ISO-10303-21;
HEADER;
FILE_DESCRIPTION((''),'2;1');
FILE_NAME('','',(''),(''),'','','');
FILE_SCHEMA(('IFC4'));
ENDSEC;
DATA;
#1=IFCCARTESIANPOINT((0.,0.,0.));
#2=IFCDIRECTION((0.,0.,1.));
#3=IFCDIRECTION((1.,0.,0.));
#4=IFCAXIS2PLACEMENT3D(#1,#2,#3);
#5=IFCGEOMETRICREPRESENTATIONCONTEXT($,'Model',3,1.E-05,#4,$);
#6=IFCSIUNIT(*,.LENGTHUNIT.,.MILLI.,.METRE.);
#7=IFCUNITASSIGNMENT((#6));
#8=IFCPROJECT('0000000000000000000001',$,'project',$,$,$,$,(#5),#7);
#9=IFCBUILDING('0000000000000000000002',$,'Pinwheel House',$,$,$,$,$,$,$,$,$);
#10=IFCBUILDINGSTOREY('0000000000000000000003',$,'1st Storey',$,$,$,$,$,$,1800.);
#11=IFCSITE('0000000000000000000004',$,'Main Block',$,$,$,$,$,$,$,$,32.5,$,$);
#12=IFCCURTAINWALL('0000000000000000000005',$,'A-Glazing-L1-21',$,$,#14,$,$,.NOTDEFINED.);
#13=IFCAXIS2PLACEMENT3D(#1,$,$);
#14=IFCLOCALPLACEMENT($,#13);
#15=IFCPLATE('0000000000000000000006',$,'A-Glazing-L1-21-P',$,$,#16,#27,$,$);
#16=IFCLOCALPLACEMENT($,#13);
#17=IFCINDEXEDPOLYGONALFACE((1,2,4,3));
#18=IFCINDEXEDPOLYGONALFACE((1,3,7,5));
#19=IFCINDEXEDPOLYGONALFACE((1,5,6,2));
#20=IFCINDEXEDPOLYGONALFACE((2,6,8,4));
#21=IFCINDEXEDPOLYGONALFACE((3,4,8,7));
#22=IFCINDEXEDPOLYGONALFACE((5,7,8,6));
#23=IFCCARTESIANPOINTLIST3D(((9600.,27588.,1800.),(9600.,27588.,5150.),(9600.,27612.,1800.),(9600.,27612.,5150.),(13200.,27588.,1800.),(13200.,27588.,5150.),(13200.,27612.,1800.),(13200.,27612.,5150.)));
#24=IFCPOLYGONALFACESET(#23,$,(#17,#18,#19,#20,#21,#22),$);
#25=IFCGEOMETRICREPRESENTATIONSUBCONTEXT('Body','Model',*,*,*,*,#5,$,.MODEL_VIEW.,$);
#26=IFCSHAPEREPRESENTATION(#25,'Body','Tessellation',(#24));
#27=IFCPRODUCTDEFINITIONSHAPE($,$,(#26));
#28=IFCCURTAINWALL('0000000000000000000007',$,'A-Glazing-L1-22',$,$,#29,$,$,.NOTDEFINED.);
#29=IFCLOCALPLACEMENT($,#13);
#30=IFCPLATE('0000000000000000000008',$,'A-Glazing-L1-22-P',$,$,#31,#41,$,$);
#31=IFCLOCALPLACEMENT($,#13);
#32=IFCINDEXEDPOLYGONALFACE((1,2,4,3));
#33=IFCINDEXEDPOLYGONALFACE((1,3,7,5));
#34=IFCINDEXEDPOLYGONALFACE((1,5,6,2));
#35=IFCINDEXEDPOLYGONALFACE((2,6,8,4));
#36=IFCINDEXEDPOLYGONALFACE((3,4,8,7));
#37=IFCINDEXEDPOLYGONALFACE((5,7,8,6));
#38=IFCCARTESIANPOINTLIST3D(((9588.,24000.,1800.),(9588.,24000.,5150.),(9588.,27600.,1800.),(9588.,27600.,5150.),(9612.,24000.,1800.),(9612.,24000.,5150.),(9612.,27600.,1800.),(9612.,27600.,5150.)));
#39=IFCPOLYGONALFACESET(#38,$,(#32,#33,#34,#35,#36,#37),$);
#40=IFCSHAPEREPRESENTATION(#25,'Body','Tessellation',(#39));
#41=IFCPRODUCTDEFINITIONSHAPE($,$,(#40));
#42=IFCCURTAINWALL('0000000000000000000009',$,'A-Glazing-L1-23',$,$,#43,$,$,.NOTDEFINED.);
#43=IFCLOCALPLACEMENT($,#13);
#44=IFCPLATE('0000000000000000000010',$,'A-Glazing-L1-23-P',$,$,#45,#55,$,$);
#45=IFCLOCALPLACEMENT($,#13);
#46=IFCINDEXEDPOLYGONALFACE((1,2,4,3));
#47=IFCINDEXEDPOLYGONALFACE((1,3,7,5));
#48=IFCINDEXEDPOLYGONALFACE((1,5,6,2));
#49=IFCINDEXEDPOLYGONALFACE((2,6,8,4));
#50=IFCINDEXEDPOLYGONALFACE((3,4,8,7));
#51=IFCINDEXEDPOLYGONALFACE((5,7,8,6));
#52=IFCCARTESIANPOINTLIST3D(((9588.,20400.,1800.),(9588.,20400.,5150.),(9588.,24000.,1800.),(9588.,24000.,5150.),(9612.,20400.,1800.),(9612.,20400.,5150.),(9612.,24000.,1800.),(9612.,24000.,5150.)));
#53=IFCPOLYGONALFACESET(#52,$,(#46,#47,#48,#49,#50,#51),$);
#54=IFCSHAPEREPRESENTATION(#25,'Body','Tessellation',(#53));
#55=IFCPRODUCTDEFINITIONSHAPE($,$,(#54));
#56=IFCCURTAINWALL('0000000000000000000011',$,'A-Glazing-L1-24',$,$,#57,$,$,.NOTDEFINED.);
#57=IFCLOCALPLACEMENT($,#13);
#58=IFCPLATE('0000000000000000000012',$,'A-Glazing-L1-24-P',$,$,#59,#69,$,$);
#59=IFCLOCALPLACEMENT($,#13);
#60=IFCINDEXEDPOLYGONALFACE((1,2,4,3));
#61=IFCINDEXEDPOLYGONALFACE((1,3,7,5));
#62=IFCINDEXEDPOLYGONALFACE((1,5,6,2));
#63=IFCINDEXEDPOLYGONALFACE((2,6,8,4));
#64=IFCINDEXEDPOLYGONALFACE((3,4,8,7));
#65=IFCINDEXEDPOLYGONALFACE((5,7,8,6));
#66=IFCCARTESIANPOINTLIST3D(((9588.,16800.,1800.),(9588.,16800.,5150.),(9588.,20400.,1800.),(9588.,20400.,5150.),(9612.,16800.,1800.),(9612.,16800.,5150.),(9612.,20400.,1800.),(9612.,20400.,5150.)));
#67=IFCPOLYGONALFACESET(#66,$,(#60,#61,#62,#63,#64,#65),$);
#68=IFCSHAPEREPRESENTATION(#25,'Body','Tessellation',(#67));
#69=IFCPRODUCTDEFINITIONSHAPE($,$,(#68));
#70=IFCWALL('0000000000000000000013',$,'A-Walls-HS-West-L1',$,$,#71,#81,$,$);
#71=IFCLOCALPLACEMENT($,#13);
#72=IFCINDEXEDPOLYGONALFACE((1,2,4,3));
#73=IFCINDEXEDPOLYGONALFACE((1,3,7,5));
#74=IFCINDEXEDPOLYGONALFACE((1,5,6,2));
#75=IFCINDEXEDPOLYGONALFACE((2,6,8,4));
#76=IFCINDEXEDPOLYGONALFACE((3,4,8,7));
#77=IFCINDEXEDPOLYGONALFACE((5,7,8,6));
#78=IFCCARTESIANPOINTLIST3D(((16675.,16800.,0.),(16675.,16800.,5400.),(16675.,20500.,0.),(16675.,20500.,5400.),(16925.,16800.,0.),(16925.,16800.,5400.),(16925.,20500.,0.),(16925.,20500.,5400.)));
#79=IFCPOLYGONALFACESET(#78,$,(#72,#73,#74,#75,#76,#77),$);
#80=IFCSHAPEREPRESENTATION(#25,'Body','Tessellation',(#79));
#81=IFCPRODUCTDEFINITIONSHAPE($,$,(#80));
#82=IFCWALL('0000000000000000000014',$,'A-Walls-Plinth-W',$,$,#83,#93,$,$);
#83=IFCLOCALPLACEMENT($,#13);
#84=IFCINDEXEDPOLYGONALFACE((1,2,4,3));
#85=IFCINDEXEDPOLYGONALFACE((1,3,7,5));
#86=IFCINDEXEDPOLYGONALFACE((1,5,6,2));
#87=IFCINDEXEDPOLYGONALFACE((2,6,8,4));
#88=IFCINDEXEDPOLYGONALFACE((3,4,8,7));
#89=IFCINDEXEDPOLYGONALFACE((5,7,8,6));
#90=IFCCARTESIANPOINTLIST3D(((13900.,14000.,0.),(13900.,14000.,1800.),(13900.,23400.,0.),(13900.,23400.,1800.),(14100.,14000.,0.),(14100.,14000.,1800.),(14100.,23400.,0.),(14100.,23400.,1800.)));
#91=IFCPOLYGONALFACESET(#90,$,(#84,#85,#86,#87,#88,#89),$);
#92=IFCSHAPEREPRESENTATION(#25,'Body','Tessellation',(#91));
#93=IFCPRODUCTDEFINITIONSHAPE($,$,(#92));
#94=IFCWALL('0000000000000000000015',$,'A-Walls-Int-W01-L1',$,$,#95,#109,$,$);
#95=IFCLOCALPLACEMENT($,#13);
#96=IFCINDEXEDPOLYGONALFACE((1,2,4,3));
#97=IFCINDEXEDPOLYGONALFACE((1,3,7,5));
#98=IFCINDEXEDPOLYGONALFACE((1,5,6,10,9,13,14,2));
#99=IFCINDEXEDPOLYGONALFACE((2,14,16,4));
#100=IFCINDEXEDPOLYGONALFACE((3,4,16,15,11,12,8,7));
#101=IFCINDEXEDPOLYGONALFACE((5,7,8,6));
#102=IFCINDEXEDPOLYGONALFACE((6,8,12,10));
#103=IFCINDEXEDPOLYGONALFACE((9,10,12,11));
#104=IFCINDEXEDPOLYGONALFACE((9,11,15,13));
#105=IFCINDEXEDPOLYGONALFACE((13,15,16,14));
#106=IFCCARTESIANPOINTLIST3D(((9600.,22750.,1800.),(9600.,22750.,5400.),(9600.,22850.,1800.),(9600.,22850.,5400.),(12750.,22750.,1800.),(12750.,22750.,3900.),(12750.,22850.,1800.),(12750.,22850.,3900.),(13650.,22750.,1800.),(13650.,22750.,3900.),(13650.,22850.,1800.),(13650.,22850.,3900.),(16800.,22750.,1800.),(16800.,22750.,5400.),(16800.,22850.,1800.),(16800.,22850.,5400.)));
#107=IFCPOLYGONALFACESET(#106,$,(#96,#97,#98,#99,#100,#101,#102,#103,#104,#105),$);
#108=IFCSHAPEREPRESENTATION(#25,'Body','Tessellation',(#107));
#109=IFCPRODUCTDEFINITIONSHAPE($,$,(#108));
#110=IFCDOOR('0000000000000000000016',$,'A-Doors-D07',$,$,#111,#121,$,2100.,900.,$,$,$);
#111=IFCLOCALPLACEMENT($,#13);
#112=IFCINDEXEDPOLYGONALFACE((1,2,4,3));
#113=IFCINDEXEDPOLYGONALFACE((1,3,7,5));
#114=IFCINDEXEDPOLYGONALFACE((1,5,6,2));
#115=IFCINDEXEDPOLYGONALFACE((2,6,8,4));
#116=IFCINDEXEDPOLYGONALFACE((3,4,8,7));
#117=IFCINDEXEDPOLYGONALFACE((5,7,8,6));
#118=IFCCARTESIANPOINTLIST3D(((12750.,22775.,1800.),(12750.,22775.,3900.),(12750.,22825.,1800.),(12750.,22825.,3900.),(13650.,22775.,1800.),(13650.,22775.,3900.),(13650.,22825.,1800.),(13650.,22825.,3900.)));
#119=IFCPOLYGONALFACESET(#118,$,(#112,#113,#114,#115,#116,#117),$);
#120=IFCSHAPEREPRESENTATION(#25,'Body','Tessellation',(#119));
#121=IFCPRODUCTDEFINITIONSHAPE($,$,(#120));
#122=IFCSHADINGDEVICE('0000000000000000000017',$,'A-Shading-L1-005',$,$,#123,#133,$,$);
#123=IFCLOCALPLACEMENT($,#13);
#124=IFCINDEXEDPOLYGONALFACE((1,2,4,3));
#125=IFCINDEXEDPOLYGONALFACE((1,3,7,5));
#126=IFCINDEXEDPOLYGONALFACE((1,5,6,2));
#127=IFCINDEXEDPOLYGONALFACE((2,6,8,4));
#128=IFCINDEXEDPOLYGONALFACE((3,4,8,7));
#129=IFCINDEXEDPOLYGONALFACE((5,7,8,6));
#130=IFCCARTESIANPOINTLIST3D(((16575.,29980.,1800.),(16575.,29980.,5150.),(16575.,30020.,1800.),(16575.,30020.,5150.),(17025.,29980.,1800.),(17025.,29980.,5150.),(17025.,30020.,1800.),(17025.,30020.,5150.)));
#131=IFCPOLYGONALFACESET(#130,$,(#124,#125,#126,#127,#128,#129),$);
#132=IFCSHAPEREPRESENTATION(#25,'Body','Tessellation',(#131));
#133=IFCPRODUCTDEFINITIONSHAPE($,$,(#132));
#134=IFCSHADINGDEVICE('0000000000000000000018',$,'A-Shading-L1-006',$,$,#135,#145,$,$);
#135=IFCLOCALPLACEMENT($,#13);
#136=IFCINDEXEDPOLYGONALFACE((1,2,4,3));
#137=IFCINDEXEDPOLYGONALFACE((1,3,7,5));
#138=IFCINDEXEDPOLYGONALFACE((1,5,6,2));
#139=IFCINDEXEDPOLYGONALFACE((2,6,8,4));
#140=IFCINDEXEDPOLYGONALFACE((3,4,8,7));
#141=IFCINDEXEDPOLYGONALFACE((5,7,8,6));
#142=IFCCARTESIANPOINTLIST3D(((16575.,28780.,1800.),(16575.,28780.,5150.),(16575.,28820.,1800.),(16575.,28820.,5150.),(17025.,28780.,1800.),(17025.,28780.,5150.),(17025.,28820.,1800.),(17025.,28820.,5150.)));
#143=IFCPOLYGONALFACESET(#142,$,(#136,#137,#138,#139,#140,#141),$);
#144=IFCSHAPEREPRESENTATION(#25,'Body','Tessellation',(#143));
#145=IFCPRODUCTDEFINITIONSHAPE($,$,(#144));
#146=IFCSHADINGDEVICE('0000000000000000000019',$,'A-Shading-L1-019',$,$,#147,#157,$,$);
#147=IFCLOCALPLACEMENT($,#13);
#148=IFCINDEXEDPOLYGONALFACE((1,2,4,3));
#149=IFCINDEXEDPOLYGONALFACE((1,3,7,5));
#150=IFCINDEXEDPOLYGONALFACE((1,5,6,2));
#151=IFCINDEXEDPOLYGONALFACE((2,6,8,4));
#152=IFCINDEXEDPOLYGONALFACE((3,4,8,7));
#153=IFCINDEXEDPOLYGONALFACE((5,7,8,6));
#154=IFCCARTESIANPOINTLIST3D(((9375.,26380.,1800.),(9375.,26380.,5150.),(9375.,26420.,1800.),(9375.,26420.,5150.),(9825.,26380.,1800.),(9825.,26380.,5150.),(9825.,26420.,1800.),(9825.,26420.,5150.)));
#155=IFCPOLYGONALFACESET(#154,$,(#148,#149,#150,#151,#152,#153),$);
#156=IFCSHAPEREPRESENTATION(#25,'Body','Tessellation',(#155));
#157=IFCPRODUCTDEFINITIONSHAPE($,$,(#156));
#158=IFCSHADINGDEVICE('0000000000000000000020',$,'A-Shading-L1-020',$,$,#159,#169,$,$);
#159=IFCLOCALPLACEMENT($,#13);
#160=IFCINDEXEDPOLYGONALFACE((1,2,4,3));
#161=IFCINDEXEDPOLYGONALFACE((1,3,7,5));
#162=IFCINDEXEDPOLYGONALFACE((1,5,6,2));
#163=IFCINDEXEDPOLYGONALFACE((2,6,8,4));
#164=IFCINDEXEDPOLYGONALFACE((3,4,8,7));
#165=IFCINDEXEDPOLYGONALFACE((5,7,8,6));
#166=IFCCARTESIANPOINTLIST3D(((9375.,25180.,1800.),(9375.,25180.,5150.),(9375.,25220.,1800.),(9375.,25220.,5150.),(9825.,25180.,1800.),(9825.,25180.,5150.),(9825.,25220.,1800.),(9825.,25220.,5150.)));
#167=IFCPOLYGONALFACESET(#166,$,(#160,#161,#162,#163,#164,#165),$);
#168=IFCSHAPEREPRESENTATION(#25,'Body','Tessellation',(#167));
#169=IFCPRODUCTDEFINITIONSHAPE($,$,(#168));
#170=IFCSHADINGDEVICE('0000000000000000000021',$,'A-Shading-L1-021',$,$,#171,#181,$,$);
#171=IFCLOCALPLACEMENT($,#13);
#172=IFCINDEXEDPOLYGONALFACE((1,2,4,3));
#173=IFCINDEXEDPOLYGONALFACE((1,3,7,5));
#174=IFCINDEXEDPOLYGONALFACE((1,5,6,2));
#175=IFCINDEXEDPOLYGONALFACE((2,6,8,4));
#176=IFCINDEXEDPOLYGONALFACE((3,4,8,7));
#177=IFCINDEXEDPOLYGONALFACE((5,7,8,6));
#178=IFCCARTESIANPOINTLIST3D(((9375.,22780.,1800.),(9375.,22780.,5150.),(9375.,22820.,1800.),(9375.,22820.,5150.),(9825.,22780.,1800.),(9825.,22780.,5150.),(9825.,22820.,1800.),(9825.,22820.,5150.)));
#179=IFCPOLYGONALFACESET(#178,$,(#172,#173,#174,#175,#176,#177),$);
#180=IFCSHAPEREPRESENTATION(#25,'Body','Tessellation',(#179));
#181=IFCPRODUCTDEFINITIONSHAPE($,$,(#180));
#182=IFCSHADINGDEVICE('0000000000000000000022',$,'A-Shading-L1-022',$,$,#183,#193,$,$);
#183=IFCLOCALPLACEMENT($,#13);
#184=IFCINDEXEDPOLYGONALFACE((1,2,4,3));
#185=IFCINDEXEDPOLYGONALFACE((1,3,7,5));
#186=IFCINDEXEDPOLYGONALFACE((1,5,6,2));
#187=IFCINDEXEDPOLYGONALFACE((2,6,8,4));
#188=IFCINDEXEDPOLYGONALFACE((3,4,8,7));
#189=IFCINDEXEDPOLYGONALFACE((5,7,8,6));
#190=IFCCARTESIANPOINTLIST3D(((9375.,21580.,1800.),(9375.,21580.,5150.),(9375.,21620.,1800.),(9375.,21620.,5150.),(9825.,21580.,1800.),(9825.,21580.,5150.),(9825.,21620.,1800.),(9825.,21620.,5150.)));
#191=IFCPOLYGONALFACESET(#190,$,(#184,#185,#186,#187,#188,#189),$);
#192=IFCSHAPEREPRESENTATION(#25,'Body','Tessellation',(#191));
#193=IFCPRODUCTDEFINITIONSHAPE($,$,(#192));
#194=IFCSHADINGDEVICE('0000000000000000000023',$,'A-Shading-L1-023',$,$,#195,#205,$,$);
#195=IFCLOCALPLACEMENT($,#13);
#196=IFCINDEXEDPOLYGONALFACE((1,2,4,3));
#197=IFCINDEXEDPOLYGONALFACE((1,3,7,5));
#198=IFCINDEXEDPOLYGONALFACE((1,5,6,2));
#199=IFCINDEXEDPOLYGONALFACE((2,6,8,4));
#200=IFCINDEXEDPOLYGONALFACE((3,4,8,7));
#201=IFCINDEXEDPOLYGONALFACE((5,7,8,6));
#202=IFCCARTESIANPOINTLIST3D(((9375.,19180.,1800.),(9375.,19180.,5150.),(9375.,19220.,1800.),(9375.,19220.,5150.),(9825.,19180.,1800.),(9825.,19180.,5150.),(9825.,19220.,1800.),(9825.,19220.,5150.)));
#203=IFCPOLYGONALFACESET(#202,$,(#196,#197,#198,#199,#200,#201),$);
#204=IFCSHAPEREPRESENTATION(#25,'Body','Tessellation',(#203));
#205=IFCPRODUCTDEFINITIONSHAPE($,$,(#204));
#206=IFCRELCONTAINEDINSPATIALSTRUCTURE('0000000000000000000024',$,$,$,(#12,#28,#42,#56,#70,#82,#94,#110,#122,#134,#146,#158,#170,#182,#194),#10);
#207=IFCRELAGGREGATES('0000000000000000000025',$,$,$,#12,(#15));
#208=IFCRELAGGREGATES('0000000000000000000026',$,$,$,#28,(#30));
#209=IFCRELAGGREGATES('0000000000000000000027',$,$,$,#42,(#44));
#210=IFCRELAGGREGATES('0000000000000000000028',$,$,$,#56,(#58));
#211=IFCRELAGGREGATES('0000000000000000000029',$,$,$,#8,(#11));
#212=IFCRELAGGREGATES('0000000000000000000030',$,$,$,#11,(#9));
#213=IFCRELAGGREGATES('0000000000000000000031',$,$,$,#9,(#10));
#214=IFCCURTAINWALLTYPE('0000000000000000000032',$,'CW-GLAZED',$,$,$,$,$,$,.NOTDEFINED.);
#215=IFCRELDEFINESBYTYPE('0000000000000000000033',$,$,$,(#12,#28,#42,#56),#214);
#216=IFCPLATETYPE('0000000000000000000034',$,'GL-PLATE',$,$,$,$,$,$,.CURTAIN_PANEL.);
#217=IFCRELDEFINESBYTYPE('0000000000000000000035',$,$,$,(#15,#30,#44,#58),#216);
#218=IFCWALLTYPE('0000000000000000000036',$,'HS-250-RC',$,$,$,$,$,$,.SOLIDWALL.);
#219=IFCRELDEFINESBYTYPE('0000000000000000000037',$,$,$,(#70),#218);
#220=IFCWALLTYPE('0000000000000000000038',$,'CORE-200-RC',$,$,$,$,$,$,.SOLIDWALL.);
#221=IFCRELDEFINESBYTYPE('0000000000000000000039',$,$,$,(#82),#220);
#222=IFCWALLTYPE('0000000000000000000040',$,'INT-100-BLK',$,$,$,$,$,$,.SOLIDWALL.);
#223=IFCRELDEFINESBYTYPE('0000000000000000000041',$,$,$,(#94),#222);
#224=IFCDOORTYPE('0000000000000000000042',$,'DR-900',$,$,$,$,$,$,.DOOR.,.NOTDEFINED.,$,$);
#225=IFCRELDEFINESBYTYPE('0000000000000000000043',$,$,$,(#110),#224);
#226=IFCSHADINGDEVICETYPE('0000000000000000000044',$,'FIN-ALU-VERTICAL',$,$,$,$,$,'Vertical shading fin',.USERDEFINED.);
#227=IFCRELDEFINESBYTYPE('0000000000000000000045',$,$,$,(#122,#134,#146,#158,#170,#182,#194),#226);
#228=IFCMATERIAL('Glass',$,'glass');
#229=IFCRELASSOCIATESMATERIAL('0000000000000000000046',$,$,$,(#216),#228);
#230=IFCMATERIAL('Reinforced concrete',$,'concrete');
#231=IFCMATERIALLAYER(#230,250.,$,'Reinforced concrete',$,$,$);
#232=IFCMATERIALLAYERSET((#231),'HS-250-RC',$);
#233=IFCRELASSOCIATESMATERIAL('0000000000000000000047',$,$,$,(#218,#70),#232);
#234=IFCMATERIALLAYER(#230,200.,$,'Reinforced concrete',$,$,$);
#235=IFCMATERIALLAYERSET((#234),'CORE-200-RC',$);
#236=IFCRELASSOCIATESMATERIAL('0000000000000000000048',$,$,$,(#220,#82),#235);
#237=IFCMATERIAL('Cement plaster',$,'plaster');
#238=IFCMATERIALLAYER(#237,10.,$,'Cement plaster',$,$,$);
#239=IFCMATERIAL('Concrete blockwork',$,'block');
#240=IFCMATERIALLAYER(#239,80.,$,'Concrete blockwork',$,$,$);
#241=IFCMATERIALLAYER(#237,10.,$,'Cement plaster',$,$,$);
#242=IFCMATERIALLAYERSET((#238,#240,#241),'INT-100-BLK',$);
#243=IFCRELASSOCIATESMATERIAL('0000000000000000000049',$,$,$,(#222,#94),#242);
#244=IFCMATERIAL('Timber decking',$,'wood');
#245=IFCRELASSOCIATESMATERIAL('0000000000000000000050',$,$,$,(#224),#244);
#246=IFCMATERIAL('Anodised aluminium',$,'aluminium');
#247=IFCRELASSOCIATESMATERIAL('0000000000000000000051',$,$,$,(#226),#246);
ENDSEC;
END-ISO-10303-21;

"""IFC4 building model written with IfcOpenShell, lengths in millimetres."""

from ifc_helpers import new_model, si_unit, frame, origin_with_axes, place, context, subcontext, project, spatial, indexed_curve, outline, extrude, material, layer, layer_set, layer_usage, type_object, element, fill, aggregate, save


model = new_model("IFC4")

# Units and contexts
model_context = context("Model", 3, precision=1e-05, world=origin_with_axes())
body_context = subcontext(model_context, "Body", "Model", "MODEL_VIEW")
ifc_project = project(units=[si_unit("LENGTHUNIT", "METRE", prefix="MILLI")], contexts=[model_context])

# Site, building, storey
site = spatial("IfcSite", under=ifc_project, Name="Main Block", RefElevation=32.5)
building = spatial("IfcBuilding", under=site, Name="Pinwheel House")
storey = spatial("IfcBuildingStorey", under=building, Name="1st Storey", Elevation=1800.0)

# Shared definitions
ifc_material_1 = material(Name="Anodised aluminium", Category="aluminium")

# Curtain walls, plates
curtain_wall_type = type_object("IfcCurtainWallType", Name="CW-GLAZED", PredefinedType="NOTDEFINED")
ifc_material_2 = material(Name="Glass", Category="glass")
plate_type = type_object("IfcPlateType", Name="GL-PLATE", PredefinedType="CURTAIN_PANEL", material=ifc_material_2)
curtain_wall_1 = element("IfcCurtainWall", 1, inside=storey, type_object=curtain_wall_type, Name="A-Glazing-L1-21", PredefinedType="NOTDEFINED")
plate_1_placement = place(None, frame((11400.0, 27600.0, 1800.0), z_axis=(0.0, 0.0, 1.0), x_axis=(-1.0, 0.0, 0.0)))
plate_1 = element("IfcPlate", 2, at=plate_1_placement, type_object=plate_type, Name="A-Glazing-L1-21-P", context=body_context, shape_type="SweptSolid", body=[
    extrude(outline(indexed_curve([(-1800.0, -12.0), (1800.0, -12.0), (1800.0, 12.0), (-1800.0, 12.0)])), None, (0.0, 0.0, 1.0), 3350.0),
])
aggregate(curtain_wall_1, [plate_1])
curtain_wall_2 = element("IfcCurtainWall", 3, inside=storey, type_object=curtain_wall_type, Name="A-Glazing-L1-22", PredefinedType="NOTDEFINED")
plate_2_placement = place(None, frame((9600.0, 25800.0, 1800.0), z_axis=(0.0, 0.0, 1.0), x_axis=(0.0, -1.0, 0.0)))
plate_2 = element("IfcPlate", 4, at=plate_2_placement, type_object=plate_type, Name="A-Glazing-L1-22-P", context=body_context, shape_type="SweptSolid", body=[
    extrude(outline(indexed_curve([(-1800.0, -12.0), (1800.0, -12.0), (1800.0, 12.0), (-1800.0, 12.0)])), None, (0.0, 0.0, 1.0), 3350.0),
])
aggregate(curtain_wall_2, [plate_2])
curtain_wall_3 = element("IfcCurtainWall", 5, inside=storey, type_object=curtain_wall_type, Name="A-Glazing-L1-23", PredefinedType="NOTDEFINED")
plate_3_placement = place(None, frame((9600.0, 22200.0, 1800.0), z_axis=(0.0, 0.0, 1.0), x_axis=(0.0, -1.0, 0.0)))
plate_3 = element("IfcPlate", 6, at=plate_3_placement, type_object=plate_type, Name="A-Glazing-L1-23-P", context=body_context, shape_type="SweptSolid", body=[
    extrude(outline(indexed_curve([(-1800.0, -12.0), (1800.0, -12.0), (1800.0, 12.0), (-1800.0, 12.0)])), None, (0.0, 0.0, 1.0), 3350.0),
])
aggregate(curtain_wall_3, [plate_3])
curtain_wall_4 = element("IfcCurtainWall", 7, inside=storey, type_object=curtain_wall_type, Name="A-Glazing-L1-24", PredefinedType="NOTDEFINED")
plate_4_placement = place(None, frame((9600.0, 18600.0, 1800.0), z_axis=(0.0, 0.0, 1.0), x_axis=(0.0, -1.0, 0.0)))
plate_4 = element("IfcPlate", 8, at=plate_4_placement, type_object=plate_type, Name="A-Glazing-L1-24-P", context=body_context, shape_type="SweptSolid", body=[
    extrude(outline(indexed_curve([(-1800.0, -12.0), (1800.0, -12.0), (1800.0, 12.0), (-1800.0, 12.0)])), None, (0.0, 0.0, 1.0), 3350.0),
])
aggregate(curtain_wall_4, [plate_4])

# Walls
ifc_material_3 = material(Name="Reinforced concrete", Category="concrete")
ifc_layer_1 = layer(ifc_material_3, 250.0, Name="Reinforced concrete")
ifc_layer_set_1 = layer_set([ifc_layer_1], Name="HS-250-RC")
ifc_layer_usage_1 = layer_usage(ifc_layer_set_1, "AXIS2", "POSITIVE", 0.0)
wall_type_1 = type_object("IfcWallType", Name="HS-250-RC", PredefinedType="SOLIDWALL", material=ifc_layer_set_1)
wall_1_placement = place(None, frame((16675.0, 20500.0, 0.0), z_axis=(0.0, 0.0, 1.0), x_axis=(0.0, -1.0, 0.0)))
element("IfcWall", 9, at=wall_1_placement, inside=storey, type_object=wall_type_1, material=ifc_layer_usage_1, Name="A-Walls-HS-West-L1", context=body_context, shape_type="SweptSolid", body=[
    extrude(outline(indexed_curve([(0.0, 0.0), (0.0, 250.0), (3700.0, 250.0), (3700.0, 0.0), (0.0, 0.0)], self_intersect=False)), origin_with_axes(), (0.0, 0.0, 1.0), 5400.0),
])
ifc_layer_2 = layer(ifc_material_3, 200.0, Name="Reinforced concrete")
ifc_layer_set_2 = layer_set([ifc_layer_2], Name="CORE-200-RC")
ifc_layer_usage_2 = layer_usage(ifc_layer_set_2, "AXIS2", "POSITIVE", 0.0)
wall_type_2 = type_object("IfcWallType", Name="CORE-200-RC", PredefinedType="SOLIDWALL", material=ifc_layer_set_2)
wall_2_placement = place(None, frame((13900.0, 23400.0, 0.0), z_axis=(0.0, 0.0, 1.0), x_axis=(0.0, -1.0, 0.0)))
element("IfcWall", 10, at=wall_2_placement, inside=storey, type_object=wall_type_2, material=ifc_layer_usage_2, Name="A-Walls-Plinth-W", context=body_context, shape_type="SweptSolid", body=[
    extrude(outline(indexed_curve([(0.0, 0.0), (0.0, 200.0), (9400.0, 200.0), (9400.0, 0.0), (0.0, 0.0)], self_intersect=False)), origin_with_axes(), (0.0, 0.0, 1.0), 1800.0),
])

# Wall, opening, door
ifc_material_4 = material(Name="Cement plaster", Category="plaster")
ifc_layer_3 = layer(ifc_material_4, 10.0, Name="Cement plaster")
ifc_material_5 = material(Name="Concrete blockwork", Category="block")
ifc_layer_4 = layer(ifc_material_5, 80.0, Name="Concrete blockwork")
ifc_layer_5 = layer(ifc_material_4, 10.0, Name="Cement plaster")
ifc_layer_set_3 = layer_set([ifc_layer_3, ifc_layer_4, ifc_layer_5], Name="INT-100-BLK")
ifc_layer_usage_3 = layer_usage(ifc_layer_set_3, "AXIS2", "POSITIVE", 0.0)
wall_type_3 = type_object("IfcWallType", Name="INT-100-BLK", PredefinedType="SOLIDWALL", material=ifc_layer_set_3)
wall_3_placement = place(None, frame((9600.0, 22750.0, 1800.0), z_axis=(0.0, 0.0, 1.0), x_axis=(1.0, 0.0, 0.0)))
wall_3 = element("IfcWall", 11, at=wall_3_placement, inside=storey, type_object=wall_type_3, material=ifc_layer_usage_3, Name="A-Walls-Int-W01-L1", context=body_context, shape_type="SweptSolid", body=[
    extrude(outline(indexed_curve([(0.0, 0.0), (0.0, 100.0), (7200.0, 100.0), (7200.0, 0.0), (0.0, 0.0)], self_intersect=False)), origin_with_axes(), (0.0, 0.0, 1.0), 3600.0),
])
opening_placement = place(wall_3_placement, frame((3600.0, 50.0, 0.0), z_axis=(0.0, 0.0, 1.0), x_axis=(1.0, 0.0, 0.0)))
opening = element("IfcOpeningElement", 12, at=opening_placement, cuts=wall_3, PredefinedType="OPENING", context=body_context, shape_type="SweptSolid", body=[
    extrude(outline(indexed_curve([(-450.0, -100.0), (450.0, -100.0), (450.0, 100.0), (-450.0, 100.0)])), None, (0.0, 0.0, 1.0), 2100.0),
])
ifc_material_6 = material(Name="Timber decking", Category="wood")
door_type = type_object("IfcDoorType", Name="DR-900", OperationType="NOTDEFINED", PredefinedType="DOOR", material=ifc_material_6)
door_placement = place(None, frame((13200.0, 22800.0, 1800.0), z_axis=(0.0, 0.0, 1.0), x_axis=(1.0, 0.0, 0.0)))
door = element("IfcDoor", 13, at=door_placement, inside=storey, type_object=door_type, Name="A-Doors-D07", OverallHeight=2100.0, OverallWidth=900.0, context=body_context, shape_type="SweptSolid", body=[
    extrude(outline(indexed_curve([(-450.0, -25.0), (450.0, -25.0), (450.0, 25.0), (-450.0, 25.0)])), None, (0.0, 0.0, 1.0), 2100.0),
])
fill(opening, door)

# Shading devices
shading_device_type = type_object("IfcShadingDeviceType", Name="FIN-ALU-VERTICAL", ElementType="Vertical shading fin", PredefinedType="USERDEFINED", material=ifc_material_1)
for number, where, z_axis, x_axis, name in (
    (14, (16800.0, 30000.0, 1800.0), (0.0, 0.0, 1.0), (0.0, -1.0, 0.0), "A-Shading-L1-005"),
    (15, (16800.0, 28800.0, 1800.0), (0.0, 0.0, 1.0), (0.0, -1.0, 0.0), "A-Shading-L1-006"),
    (16, (9600.0, 26400.0, 1800.0), (0.0, 0.0, 1.0), (0.0, -1.0, 0.0), "A-Shading-L1-019"),
    (17, (9600.0, 25200.0, 1800.0), (0.0, 0.0, 1.0), (0.0, -1.0, 0.0), "A-Shading-L1-020"),
    (18, (9600.0, 22800.0, 1800.0), (0.0, 0.0, 1.0), (0.0, -1.0, 0.0), "A-Shading-L1-021"),
    (19, (9600.0, 21600.0, 1800.0), (0.0, 0.0, 1.0), (0.0, -1.0, 0.0), "A-Shading-L1-022"),
    (20, (9600.0, 19200.0, 1800.0), (0.0, 0.0, 1.0), (0.0, -1.0, 0.0), "A-Shading-L1-023"),
):
    element("IfcShadingDevice", number, at=place(None, frame(where, z_axis=z_axis, x_axis=x_axis)), inside=storey, type_object=shading_device_type, Name=name, context=body_context, shape_type="SweptSolid", body=[
        extrude(outline(indexed_curve([(-20.0, -225.0), (20.0, -225.0), (20.0, 225.0), (-20.0, 225.0)])), None, (0.0, 0.0, 1.0), 3350.0),
    ])

save(model, "model.ifc")
